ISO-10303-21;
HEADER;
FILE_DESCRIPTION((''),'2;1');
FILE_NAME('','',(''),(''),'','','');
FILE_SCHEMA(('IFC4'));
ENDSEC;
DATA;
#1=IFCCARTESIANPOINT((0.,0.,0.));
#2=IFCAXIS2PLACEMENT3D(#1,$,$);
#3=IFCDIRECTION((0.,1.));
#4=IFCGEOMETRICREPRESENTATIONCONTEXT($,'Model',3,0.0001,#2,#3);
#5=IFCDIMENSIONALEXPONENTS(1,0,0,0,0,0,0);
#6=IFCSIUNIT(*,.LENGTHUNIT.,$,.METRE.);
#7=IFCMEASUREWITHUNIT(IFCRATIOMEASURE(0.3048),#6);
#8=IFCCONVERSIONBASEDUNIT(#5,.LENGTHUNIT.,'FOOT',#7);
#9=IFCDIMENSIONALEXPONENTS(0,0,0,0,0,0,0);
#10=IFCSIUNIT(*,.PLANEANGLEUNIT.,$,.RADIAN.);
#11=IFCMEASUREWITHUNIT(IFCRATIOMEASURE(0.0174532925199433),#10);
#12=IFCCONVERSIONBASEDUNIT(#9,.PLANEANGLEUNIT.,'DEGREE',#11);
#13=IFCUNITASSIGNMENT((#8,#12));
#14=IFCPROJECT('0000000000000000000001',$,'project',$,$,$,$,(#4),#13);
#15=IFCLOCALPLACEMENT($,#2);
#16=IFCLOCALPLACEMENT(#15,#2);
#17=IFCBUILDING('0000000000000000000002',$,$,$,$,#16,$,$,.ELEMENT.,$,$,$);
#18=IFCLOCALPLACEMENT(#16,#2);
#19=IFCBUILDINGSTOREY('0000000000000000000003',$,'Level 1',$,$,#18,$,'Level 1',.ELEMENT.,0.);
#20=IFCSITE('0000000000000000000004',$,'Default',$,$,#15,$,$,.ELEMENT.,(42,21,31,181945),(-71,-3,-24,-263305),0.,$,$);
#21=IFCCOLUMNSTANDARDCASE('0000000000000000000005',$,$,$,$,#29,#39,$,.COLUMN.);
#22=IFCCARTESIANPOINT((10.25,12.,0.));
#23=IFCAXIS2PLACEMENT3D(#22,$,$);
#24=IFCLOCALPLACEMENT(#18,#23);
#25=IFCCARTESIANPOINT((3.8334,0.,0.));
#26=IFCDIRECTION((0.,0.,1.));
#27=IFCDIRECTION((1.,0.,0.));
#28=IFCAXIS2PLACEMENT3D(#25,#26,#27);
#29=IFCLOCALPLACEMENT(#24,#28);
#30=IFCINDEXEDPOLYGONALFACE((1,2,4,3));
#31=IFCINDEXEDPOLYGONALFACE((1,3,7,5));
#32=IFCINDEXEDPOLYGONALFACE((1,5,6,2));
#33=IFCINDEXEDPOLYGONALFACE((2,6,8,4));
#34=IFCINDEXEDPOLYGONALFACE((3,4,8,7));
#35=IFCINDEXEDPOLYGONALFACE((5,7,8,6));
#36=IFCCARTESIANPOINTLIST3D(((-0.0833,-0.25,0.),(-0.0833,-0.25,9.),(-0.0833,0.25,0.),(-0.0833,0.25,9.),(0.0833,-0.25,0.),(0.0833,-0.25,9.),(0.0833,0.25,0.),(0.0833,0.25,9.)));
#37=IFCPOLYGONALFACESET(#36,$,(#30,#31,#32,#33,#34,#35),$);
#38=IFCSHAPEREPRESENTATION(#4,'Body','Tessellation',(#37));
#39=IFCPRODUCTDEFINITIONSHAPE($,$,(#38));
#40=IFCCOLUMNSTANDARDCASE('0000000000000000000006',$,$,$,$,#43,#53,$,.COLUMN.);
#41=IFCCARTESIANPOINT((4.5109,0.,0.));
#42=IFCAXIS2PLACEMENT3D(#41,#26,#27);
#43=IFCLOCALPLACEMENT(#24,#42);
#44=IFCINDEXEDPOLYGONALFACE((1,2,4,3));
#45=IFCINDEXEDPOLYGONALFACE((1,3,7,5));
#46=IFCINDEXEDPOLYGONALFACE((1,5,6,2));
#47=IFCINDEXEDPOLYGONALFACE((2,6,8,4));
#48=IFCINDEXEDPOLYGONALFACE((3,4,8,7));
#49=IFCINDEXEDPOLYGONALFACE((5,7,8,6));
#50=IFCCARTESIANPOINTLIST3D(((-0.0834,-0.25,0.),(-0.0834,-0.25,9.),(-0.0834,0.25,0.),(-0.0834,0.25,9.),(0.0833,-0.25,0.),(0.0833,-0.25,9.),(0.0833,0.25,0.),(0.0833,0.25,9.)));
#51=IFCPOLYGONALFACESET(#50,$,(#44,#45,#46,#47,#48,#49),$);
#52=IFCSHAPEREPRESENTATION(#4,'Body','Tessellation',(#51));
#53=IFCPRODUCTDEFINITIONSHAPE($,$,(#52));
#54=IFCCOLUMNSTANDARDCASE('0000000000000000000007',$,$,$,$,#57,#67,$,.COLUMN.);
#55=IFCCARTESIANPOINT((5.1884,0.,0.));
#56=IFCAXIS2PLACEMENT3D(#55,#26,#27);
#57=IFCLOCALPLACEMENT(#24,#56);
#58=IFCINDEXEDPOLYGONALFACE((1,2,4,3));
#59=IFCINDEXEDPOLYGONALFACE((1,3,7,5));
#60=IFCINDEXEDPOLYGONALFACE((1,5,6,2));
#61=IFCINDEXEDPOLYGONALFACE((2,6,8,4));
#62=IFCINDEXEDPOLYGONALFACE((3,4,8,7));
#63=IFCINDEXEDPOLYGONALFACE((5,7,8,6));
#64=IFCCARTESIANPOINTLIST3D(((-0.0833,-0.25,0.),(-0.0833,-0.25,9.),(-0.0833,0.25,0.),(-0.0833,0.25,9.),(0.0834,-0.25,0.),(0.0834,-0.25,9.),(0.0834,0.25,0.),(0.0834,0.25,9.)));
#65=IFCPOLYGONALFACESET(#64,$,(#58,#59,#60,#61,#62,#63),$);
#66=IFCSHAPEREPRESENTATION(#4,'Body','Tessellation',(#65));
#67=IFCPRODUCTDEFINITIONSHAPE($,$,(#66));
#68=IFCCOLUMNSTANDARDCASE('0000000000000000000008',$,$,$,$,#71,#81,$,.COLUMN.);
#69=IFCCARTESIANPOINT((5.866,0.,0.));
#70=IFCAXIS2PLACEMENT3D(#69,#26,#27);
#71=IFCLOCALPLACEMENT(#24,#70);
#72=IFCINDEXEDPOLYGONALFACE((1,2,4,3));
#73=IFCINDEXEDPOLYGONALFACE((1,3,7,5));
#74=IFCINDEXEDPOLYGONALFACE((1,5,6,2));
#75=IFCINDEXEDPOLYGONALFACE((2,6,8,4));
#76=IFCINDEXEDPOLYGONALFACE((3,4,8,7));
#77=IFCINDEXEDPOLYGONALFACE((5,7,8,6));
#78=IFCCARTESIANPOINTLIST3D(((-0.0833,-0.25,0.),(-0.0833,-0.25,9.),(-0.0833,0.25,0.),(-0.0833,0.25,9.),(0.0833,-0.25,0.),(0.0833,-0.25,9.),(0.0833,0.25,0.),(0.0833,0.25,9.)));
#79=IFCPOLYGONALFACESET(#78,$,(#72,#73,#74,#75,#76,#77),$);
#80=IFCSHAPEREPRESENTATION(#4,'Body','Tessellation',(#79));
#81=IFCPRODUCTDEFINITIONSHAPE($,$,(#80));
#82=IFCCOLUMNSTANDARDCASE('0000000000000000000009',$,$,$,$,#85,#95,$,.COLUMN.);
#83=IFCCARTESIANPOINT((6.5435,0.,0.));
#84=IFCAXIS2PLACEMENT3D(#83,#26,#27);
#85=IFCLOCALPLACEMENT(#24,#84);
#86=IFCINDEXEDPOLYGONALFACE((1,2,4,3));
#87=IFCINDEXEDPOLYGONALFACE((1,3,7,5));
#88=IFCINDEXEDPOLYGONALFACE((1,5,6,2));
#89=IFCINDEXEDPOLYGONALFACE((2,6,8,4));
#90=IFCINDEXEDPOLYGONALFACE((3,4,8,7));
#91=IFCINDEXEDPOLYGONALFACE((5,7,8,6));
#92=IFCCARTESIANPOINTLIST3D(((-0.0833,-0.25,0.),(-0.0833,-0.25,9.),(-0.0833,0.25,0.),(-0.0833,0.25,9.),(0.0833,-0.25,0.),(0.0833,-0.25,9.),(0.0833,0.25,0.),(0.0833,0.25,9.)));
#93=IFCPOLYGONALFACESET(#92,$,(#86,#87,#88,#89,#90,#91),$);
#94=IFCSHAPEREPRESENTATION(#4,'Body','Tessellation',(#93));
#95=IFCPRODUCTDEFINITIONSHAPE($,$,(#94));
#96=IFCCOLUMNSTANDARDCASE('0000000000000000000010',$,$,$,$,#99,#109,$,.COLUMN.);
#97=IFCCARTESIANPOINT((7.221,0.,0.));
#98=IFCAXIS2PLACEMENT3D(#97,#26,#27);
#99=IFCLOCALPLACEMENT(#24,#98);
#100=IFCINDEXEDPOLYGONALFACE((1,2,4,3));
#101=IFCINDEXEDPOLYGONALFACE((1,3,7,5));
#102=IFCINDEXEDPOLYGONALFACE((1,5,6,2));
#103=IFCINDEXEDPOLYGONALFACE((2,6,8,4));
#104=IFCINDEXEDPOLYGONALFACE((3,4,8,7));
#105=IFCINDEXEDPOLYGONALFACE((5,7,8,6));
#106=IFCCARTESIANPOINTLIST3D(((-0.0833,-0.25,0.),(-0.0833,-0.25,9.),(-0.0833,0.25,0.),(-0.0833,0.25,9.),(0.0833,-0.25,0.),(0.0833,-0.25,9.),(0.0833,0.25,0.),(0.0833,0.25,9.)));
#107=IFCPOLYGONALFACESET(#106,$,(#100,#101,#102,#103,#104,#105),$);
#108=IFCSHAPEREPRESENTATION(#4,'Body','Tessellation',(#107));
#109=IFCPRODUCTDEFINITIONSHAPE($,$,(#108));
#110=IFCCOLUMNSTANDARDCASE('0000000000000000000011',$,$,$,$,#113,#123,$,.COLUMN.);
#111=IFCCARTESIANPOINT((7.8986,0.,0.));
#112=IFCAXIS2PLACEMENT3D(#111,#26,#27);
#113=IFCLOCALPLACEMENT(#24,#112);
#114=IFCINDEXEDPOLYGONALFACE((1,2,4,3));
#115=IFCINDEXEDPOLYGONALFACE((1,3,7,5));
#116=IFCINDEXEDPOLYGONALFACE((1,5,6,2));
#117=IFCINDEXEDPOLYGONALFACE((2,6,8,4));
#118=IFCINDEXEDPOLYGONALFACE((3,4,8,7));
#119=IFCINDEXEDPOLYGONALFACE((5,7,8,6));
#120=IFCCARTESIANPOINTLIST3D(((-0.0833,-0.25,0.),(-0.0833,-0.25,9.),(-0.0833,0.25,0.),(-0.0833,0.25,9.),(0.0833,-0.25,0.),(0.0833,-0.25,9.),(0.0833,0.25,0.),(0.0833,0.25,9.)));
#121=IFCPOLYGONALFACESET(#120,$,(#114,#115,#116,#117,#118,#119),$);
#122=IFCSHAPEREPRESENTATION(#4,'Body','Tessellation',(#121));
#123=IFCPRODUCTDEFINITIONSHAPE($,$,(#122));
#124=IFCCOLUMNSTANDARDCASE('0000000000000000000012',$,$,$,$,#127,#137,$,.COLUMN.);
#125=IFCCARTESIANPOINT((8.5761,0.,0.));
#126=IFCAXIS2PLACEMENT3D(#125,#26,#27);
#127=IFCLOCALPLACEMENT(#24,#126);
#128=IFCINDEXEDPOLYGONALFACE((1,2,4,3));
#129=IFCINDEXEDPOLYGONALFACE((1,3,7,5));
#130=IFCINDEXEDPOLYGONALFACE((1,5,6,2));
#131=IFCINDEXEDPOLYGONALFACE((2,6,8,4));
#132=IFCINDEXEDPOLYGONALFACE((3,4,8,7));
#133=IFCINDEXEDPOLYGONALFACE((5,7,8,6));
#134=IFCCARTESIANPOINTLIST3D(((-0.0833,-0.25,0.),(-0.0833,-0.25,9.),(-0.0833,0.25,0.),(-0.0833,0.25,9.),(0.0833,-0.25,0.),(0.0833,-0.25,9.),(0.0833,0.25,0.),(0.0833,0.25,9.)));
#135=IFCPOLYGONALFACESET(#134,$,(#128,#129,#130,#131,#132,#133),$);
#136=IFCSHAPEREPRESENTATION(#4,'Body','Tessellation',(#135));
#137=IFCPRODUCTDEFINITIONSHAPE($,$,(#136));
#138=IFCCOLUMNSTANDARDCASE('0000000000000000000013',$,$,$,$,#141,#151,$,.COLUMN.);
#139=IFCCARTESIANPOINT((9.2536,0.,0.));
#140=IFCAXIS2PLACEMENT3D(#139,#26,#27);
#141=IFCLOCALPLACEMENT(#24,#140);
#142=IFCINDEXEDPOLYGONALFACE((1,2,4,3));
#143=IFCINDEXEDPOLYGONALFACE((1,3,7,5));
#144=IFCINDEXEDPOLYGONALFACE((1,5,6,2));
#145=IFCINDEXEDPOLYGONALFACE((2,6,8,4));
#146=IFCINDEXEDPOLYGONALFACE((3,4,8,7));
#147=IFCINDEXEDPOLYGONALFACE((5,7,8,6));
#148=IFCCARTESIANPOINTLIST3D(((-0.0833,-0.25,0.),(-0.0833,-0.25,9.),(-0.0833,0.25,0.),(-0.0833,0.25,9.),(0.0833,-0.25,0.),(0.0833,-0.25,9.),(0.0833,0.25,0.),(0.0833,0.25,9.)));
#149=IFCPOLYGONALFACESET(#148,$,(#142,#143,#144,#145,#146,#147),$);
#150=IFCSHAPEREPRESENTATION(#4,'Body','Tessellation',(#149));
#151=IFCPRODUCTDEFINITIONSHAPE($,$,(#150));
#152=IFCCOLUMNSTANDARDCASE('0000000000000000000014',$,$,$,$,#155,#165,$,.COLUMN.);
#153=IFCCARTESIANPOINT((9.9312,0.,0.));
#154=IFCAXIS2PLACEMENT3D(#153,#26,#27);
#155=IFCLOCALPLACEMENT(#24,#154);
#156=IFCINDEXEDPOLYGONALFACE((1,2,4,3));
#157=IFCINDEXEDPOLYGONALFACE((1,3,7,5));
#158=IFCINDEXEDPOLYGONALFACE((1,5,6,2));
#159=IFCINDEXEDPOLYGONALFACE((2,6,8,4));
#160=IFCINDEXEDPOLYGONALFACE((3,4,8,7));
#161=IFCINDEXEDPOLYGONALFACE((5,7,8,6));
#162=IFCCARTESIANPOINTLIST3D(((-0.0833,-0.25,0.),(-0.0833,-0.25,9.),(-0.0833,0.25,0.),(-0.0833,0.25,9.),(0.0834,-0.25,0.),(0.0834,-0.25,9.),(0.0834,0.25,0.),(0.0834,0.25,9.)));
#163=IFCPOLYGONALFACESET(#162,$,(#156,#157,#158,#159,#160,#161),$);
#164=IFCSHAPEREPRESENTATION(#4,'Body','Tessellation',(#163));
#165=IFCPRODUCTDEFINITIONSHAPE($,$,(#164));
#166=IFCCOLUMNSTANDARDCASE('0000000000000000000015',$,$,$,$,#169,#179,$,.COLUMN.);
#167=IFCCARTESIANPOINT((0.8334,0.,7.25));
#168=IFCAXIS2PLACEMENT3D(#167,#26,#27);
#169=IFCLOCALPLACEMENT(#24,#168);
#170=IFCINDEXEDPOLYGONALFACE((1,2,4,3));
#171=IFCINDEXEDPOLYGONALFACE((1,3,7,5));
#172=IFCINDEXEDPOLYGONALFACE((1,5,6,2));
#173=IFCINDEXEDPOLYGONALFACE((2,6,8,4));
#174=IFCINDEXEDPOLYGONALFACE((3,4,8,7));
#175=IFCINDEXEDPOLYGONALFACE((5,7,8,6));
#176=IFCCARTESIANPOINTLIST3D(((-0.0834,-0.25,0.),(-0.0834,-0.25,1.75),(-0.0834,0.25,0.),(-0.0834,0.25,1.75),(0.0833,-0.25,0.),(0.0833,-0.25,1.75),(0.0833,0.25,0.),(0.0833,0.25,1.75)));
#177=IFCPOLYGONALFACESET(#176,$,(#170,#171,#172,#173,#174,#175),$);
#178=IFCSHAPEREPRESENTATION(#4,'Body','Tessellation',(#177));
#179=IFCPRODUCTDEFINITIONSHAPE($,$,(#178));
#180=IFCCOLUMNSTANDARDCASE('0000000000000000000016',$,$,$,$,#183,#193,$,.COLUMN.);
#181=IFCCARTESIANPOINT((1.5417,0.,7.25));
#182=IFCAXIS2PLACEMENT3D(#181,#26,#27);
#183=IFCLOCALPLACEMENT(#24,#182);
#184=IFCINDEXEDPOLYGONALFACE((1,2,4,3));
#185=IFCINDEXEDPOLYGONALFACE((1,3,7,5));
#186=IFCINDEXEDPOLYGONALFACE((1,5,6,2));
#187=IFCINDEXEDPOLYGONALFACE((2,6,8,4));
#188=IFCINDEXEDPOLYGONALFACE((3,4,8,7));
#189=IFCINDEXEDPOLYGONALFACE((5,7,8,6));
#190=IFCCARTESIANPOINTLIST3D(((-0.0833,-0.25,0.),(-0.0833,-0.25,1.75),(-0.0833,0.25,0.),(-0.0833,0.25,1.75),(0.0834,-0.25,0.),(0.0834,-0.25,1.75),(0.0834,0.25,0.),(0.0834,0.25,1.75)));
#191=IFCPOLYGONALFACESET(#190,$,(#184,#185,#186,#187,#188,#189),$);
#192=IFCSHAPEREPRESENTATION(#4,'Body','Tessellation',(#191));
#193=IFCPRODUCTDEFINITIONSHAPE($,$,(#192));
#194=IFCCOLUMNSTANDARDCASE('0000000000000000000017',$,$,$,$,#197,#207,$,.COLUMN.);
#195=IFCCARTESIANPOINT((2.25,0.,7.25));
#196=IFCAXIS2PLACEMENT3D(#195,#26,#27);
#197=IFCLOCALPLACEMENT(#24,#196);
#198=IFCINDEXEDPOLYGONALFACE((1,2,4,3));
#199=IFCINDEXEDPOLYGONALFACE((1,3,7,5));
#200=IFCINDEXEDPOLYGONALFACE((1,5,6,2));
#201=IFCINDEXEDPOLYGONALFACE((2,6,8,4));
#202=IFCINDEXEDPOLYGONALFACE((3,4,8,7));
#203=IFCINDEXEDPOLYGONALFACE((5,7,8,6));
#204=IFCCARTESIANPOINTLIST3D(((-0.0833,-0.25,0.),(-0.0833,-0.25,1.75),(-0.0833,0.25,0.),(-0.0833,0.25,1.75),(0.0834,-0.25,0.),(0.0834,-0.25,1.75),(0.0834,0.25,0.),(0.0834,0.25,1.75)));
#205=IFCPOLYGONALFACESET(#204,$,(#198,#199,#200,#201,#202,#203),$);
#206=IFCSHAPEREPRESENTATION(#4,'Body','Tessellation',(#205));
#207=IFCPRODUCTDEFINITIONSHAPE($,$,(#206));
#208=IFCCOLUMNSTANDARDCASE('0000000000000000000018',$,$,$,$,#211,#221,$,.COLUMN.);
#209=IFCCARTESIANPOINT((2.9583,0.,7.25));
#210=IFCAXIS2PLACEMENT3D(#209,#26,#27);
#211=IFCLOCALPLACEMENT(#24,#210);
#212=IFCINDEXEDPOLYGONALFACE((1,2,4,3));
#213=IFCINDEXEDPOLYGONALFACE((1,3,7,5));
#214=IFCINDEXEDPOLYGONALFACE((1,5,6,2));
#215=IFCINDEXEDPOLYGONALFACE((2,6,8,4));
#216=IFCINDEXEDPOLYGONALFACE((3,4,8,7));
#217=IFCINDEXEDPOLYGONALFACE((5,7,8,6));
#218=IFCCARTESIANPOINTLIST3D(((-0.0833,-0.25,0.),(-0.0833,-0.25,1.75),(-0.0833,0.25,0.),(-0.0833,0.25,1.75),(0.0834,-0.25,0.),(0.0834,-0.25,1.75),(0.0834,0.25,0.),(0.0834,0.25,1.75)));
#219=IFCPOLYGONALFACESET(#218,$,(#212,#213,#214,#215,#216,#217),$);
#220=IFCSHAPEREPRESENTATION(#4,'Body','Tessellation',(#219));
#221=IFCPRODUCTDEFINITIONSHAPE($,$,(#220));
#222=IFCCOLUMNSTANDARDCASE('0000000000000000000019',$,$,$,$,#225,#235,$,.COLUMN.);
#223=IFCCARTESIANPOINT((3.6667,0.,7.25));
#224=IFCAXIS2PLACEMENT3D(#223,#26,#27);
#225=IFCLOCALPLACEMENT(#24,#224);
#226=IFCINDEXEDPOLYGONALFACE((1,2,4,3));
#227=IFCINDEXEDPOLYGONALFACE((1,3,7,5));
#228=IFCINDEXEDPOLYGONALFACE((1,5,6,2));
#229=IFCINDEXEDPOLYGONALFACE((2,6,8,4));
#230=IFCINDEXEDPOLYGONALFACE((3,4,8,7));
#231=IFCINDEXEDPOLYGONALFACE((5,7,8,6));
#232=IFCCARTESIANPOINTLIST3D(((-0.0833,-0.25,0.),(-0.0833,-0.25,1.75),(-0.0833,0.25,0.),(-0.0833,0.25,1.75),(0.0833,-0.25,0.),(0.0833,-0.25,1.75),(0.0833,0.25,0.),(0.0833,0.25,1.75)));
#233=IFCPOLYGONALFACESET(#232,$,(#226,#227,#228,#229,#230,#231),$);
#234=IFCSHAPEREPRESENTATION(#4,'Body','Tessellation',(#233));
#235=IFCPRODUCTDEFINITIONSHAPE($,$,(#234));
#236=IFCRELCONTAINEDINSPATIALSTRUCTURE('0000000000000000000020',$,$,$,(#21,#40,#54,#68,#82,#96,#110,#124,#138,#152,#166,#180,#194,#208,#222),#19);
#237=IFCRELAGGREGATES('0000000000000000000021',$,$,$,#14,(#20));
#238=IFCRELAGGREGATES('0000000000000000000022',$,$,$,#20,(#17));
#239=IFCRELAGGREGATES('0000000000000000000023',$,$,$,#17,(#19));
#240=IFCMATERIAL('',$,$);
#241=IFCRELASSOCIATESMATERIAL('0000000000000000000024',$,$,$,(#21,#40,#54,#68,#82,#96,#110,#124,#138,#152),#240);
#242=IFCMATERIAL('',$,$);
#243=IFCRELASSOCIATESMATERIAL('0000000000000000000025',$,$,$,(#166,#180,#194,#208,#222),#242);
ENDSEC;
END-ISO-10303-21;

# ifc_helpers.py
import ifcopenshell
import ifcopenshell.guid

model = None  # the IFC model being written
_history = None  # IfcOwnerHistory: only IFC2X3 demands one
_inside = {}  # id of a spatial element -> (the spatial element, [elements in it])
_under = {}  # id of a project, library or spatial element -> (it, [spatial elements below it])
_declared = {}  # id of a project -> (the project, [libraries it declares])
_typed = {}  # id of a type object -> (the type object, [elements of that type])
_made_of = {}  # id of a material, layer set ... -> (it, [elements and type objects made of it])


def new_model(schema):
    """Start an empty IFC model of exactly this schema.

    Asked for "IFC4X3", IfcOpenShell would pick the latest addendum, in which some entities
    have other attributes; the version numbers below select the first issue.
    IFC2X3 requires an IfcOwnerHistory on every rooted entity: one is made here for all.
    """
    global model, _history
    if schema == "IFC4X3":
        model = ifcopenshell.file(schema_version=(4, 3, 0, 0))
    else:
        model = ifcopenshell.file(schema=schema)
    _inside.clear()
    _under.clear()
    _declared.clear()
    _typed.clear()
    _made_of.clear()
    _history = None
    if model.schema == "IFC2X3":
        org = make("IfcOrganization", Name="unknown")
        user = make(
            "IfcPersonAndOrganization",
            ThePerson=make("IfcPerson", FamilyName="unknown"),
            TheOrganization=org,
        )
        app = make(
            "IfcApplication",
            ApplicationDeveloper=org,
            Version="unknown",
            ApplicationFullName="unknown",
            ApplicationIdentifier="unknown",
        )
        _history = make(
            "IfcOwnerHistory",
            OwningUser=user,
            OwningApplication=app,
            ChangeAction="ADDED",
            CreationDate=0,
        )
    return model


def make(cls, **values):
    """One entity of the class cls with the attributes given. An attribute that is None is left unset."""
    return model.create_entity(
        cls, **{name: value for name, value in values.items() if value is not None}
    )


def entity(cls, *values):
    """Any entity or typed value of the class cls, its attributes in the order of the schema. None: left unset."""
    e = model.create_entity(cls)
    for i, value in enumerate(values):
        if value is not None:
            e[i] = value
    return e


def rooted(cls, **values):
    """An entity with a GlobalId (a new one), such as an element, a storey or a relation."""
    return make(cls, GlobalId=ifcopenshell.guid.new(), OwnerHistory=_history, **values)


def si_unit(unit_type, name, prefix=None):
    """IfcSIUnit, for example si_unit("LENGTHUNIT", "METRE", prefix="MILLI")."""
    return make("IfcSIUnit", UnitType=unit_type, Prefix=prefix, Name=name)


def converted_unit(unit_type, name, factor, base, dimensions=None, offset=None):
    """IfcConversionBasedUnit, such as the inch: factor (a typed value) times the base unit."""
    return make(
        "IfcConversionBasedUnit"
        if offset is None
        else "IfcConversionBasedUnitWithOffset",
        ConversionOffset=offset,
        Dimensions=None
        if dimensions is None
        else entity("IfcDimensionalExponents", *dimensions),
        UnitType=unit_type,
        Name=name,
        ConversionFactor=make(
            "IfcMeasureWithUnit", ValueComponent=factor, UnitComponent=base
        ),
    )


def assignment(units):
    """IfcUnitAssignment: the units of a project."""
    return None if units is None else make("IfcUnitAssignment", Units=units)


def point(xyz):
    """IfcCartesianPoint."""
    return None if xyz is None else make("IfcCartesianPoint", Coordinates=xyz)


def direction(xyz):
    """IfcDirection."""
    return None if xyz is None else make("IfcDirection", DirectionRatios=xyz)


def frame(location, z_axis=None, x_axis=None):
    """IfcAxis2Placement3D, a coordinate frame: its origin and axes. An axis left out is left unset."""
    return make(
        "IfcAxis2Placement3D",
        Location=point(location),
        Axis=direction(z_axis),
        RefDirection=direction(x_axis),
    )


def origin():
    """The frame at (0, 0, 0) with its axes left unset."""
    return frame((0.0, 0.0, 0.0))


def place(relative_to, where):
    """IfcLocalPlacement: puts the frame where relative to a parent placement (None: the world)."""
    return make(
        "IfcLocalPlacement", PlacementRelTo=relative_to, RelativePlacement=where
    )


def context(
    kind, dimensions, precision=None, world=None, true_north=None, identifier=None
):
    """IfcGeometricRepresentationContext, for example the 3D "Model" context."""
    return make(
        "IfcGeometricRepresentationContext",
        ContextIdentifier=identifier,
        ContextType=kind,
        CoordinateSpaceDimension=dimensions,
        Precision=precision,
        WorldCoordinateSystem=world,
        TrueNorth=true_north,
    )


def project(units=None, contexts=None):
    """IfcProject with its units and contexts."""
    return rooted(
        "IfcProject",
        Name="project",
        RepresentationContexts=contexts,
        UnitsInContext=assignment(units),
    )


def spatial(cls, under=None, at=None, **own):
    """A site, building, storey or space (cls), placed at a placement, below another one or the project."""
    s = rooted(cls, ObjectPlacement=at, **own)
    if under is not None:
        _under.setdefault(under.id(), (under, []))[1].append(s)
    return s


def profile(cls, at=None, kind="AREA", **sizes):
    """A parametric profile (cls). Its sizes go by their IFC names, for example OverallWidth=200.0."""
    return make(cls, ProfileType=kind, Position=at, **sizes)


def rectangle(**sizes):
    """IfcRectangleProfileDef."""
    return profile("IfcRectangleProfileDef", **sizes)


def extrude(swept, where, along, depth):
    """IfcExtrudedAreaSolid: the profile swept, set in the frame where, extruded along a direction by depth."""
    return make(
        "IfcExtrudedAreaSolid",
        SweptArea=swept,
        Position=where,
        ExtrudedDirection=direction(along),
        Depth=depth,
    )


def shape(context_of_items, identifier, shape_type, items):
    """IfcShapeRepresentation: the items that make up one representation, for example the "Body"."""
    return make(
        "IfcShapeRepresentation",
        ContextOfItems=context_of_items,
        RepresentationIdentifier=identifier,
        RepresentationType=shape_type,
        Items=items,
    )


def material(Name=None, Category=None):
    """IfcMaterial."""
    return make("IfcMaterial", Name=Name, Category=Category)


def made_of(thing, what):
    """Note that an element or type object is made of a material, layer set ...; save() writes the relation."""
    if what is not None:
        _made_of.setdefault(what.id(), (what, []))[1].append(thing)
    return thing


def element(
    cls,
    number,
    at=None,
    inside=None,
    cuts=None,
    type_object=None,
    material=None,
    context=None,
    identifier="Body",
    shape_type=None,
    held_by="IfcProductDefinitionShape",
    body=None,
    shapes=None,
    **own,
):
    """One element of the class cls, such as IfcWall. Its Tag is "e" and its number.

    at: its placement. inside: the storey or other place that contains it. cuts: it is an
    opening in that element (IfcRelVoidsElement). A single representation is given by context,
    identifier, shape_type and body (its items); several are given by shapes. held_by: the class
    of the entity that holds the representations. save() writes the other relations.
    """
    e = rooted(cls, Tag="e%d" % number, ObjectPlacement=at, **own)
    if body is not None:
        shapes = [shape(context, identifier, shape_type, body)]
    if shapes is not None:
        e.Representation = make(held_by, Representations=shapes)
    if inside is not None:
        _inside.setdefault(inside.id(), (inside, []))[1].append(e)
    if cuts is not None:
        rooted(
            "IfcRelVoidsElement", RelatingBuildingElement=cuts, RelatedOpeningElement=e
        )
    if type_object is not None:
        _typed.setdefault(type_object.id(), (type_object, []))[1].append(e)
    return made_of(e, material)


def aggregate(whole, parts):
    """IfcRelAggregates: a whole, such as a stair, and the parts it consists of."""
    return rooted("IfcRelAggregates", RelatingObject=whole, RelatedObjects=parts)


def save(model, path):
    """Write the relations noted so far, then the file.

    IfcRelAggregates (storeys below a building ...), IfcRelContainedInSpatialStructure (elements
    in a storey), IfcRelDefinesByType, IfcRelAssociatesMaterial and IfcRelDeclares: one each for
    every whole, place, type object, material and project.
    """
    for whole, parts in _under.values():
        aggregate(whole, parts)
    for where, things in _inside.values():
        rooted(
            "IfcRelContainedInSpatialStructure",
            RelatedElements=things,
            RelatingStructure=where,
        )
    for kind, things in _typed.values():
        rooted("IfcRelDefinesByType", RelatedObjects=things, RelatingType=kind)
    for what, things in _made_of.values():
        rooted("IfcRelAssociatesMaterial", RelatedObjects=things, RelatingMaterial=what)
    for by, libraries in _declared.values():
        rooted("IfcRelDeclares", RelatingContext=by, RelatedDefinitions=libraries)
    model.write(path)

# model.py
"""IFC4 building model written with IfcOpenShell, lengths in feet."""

from ifc_helpers import new_model, entity, si_unit, converted_unit, direction, frame, origin, place, context, project, spatial, rectangle, extrude, material, element, save


model = new_model("IFC4")

# Units and contexts
model_context = context("Model", 3, precision=0.0001, world=origin(), true_north=direction((0.0, 1.0)))
ifc_project = project(units=[converted_unit("LENGTHUNIT", "FOOT", entity("IfcRatioMeasure", 0.3048), si_unit("LENGTHUNIT", "METRE"), dimensions=[1, 0, 0, 0, 0, 0, 0]), converted_unit("PLANEANGLEUNIT", "DEGREE", entity("IfcRatioMeasure", 0.0174532925199433), si_unit("PLANEANGLEUNIT", "RADIAN"), dimensions=[0, 0, 0, 0, 0, 0, 0])], contexts=[model_context])

# Site, building, storey
site_placement = place(None, origin())
site = spatial("IfcSite", under=ifc_project, at=site_placement, Name="Default", CompositionType="ELEMENT", RefLatitude=(42, 21, 31, 181945), RefLongitude=(-71, -3, -24, -263305), RefElevation=0.0)
building_placement = place(site_placement, origin())
building = spatial("IfcBuilding", under=site, at=building_placement, CompositionType="ELEMENT")
storey_placement = place(building_placement, origin())
storey = spatial("IfcBuildingStorey", under=building, at=storey_placement, Name="Level 1", LongName="Level 1", CompositionType="ELEMENT", Elevation=0.0)

# Columns
ifc_material_1 = material(Name="")
placement_1 = place(storey_placement, frame((10.25, 12.0, 0.0)))
for number, where, z_axis, x_axis in (
    (1, (3.8334, 0.0, 0.0), (0.0, 0.0, 1.0), (1.0, 0.0, 0.0)),
    (2, (4.5109, 0.0, 0.0), (0.0, 0.0, 1.0), (1.0, 0.0, 0.0)),
    (3, (5.1884, 0.0, 0.0), (0.0, 0.0, 1.0), (1.0, 0.0, 0.0)),
    (4, (5.866, 0.0, 0.0), (0.0, 0.0, 1.0), (1.0, 0.0, 0.0)),
    (5, (6.5435, 0.0, 0.0), (0.0, 0.0, 1.0), (1.0, 0.0, 0.0)),
    (6, (7.221, 0.0, 0.0), (0.0, 0.0, 1.0), (1.0, 0.0, 0.0)),
    (7, (7.8986, 0.0, 0.0), (0.0, 0.0, 1.0), (1.0, 0.0, 0.0)),
    (8, (8.5761, 0.0, 0.0), (0.0, 0.0, 1.0), (1.0, 0.0, 0.0)),
    (9, (9.2536, 0.0, 0.0), (0.0, 0.0, 1.0), (1.0, 0.0, 0.0)),
    (10, (9.9312, 0.0, 0.0), (0.0, 0.0, 1.0), (1.0, 0.0, 0.0)),
):
    element("IfcColumnStandardCase", number, at=place(placement_1, frame(where, z_axis=z_axis, x_axis=x_axis)), inside=storey, material=ifc_material_1, PredefinedType="COLUMN", context=model_context, shape_type="SweptSolid", body=[
        extrude(rectangle(XDim=0.1667, YDim=0.5), origin(), (0.0, 0.0, 1.0), 9.0),
    ])
ifc_material_2 = material(Name="")
for number, where, z_axis, x_axis in (
    (11, (0.8334, 0.0, 7.25), (0.0, 0.0, 1.0), (1.0, 0.0, 0.0)),
    (12, (1.5417, 0.0, 7.25), (0.0, 0.0, 1.0), (1.0, 0.0, 0.0)),
    (13, (2.25, 0.0, 7.25), (0.0, 0.0, 1.0), (1.0, 0.0, 0.0)),
    (14, (2.9583, 0.0, 7.25), (0.0, 0.0, 1.0), (1.0, 0.0, 0.0)),
    (15, (3.6667, 0.0, 7.25), (0.0, 0.0, 1.0), (1.0, 0.0, 0.0)),
):
    element("IfcColumnStandardCase", number, at=place(placement_1, frame(where, z_axis=z_axis, x_axis=x_axis)), inside=storey, material=ifc_material_2, PredefinedType="COLUMN", context=model_context, shape_type="SweptSolid", body=[
        extrude(rectangle(XDim=0.1667, YDim=0.5), origin(), (0.0, 0.0, 1.0), 1.75),
    ])

save(model, "model.ifc")
